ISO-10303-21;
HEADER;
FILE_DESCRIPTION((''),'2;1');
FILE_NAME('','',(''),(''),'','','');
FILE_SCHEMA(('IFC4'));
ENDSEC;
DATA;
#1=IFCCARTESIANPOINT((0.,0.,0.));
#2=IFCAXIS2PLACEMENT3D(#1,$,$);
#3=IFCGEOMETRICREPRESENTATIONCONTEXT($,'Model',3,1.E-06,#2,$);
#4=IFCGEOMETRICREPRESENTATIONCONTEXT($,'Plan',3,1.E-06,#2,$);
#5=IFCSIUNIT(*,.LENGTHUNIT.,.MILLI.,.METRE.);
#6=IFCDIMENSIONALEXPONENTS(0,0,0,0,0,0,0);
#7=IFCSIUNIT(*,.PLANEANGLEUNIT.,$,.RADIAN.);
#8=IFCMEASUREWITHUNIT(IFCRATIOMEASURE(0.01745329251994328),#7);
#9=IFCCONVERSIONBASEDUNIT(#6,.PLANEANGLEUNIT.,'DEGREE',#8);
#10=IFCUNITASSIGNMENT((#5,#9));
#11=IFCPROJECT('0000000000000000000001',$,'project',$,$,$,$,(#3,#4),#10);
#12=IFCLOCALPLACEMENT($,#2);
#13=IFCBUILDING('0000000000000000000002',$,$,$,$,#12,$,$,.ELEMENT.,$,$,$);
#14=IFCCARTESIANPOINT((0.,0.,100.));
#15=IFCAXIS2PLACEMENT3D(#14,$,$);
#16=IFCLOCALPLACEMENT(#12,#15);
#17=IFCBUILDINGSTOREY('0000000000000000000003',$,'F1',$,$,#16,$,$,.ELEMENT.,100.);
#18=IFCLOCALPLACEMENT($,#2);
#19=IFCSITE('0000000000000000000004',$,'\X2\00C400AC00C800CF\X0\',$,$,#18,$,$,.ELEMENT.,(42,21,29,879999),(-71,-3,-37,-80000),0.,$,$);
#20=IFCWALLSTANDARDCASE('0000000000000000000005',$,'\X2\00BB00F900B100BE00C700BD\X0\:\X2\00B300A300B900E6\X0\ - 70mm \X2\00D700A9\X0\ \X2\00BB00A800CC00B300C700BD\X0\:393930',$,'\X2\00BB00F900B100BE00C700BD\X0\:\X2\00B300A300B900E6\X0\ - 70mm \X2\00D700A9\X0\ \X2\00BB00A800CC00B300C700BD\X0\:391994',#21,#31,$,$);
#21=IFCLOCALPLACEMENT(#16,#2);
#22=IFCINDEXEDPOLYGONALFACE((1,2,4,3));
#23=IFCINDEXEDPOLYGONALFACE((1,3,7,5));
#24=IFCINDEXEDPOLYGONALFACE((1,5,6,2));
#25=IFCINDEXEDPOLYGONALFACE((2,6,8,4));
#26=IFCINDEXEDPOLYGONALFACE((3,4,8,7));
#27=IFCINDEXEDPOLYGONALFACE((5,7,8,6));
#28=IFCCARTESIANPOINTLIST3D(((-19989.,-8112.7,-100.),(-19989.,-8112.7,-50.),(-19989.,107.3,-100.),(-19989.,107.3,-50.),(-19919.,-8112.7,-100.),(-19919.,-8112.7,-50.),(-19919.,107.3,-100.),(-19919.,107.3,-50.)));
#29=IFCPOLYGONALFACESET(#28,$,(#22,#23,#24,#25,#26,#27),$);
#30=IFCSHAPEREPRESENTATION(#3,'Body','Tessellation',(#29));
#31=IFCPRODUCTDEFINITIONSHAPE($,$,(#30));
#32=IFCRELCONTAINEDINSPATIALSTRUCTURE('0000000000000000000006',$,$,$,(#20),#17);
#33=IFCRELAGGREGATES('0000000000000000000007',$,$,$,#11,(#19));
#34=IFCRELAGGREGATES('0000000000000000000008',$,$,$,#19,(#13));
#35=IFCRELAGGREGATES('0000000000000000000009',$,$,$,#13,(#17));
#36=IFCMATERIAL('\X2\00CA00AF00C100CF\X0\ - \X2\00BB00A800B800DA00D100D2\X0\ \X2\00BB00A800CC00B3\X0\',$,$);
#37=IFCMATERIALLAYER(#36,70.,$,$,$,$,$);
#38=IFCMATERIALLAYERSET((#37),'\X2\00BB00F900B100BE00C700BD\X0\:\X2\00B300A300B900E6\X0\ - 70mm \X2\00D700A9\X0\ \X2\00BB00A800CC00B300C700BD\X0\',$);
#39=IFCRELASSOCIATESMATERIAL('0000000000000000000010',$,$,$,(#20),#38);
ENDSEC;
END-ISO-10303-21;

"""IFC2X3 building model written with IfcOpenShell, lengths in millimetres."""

from ifc_helpers import new_model, entity, si_unit, converted_unit, frame, frame_2d, origin, place, context, project, spatial, rectangle, extrude, material, layer, layer_set, layer_usage, element, save


model = new_model("IFC2X3")

# Units and contexts
model_context = context("Model", 3, precision=1e-06, world=origin())
plan_context = context("Plan", 3, precision=1e-06, world=origin())
ifc_project = project(units=[si_unit("LENGTHUNIT", "METRE", prefix="MILLI"), converted_unit("PLANEANGLEUNIT", "DEGREE", entity("IfcRatioMeasure", 0.01745329251994328), si_unit("PLANEANGLEUNIT", "RADIAN"), dimensions=[0, 0, 0, 0, 0, 0, 0])], contexts=[model_context, plan_context])

# Site, building, storey
site_placement = place(None, origin())
site = spatial("IfcSite", under=ifc_project, at=site_placement, Name="Ä¬ÈÏ", CompositionType="ELEMENT", RefLatitude=(42, 21, 29, 879999), RefLongitude=(-71, -3, -37, -80000), RefElevation=0.0)
building_placement = place(None, origin())
building = spatial("IfcBuilding", under=site, at=building_placement, CompositionType="ELEMENT")
storey_placement = place(building_placement, frame((0.0, 0.0, 100.0)))
storey = spatial("IfcBuildingStorey", under=building, at=storey_placement, Name="F1", CompositionType="ELEMENT", Elevation=100.0)

# Wall
ifc_material = material(Name="Ê¯ÁÏ - »¨¸ÚÑÒ »¨Ì³")
ifc_layer = layer(ifc_material, 70.0)
ifc_layer_set = layer_set([ifc_layer], Name="»ù±¾Ç½:³£¹æ - 70mm ×© »¨Ì³Ç½")
ifc_layer_usage = layer_usage(ifc_layer_set, "AXIS2", "NEGATIVE", 35.0)
wall_placement = place(storey_placement, frame((-19954.0, 107.3, -100.0), z_axis=(0.0, 0.0, 1.0), x_axis=(0.0, -1.0, 0.0)))
element("IfcWallStandardCase", 1, at=wall_placement, inside=storey, material=ifc_layer_usage, Name="»ù±¾Ç½:³£¹æ - 70mm ×© »¨Ì³Ç½:393930", ObjectType="»ù±¾Ç½:³£¹æ - 70mm ×© »¨Ì³Ç½:391994", context=model_context, shape_type="SweptSolid", body=[
    extrude(rectangle(XDim=8220.0, YDim=70.0, at=frame_2d((4110.0, 0.0), x_axis=(-1.0, 0.0))), origin(), (0.0, 0.0, 1.0), 50.0),
])

save(model, "model.ifc")
